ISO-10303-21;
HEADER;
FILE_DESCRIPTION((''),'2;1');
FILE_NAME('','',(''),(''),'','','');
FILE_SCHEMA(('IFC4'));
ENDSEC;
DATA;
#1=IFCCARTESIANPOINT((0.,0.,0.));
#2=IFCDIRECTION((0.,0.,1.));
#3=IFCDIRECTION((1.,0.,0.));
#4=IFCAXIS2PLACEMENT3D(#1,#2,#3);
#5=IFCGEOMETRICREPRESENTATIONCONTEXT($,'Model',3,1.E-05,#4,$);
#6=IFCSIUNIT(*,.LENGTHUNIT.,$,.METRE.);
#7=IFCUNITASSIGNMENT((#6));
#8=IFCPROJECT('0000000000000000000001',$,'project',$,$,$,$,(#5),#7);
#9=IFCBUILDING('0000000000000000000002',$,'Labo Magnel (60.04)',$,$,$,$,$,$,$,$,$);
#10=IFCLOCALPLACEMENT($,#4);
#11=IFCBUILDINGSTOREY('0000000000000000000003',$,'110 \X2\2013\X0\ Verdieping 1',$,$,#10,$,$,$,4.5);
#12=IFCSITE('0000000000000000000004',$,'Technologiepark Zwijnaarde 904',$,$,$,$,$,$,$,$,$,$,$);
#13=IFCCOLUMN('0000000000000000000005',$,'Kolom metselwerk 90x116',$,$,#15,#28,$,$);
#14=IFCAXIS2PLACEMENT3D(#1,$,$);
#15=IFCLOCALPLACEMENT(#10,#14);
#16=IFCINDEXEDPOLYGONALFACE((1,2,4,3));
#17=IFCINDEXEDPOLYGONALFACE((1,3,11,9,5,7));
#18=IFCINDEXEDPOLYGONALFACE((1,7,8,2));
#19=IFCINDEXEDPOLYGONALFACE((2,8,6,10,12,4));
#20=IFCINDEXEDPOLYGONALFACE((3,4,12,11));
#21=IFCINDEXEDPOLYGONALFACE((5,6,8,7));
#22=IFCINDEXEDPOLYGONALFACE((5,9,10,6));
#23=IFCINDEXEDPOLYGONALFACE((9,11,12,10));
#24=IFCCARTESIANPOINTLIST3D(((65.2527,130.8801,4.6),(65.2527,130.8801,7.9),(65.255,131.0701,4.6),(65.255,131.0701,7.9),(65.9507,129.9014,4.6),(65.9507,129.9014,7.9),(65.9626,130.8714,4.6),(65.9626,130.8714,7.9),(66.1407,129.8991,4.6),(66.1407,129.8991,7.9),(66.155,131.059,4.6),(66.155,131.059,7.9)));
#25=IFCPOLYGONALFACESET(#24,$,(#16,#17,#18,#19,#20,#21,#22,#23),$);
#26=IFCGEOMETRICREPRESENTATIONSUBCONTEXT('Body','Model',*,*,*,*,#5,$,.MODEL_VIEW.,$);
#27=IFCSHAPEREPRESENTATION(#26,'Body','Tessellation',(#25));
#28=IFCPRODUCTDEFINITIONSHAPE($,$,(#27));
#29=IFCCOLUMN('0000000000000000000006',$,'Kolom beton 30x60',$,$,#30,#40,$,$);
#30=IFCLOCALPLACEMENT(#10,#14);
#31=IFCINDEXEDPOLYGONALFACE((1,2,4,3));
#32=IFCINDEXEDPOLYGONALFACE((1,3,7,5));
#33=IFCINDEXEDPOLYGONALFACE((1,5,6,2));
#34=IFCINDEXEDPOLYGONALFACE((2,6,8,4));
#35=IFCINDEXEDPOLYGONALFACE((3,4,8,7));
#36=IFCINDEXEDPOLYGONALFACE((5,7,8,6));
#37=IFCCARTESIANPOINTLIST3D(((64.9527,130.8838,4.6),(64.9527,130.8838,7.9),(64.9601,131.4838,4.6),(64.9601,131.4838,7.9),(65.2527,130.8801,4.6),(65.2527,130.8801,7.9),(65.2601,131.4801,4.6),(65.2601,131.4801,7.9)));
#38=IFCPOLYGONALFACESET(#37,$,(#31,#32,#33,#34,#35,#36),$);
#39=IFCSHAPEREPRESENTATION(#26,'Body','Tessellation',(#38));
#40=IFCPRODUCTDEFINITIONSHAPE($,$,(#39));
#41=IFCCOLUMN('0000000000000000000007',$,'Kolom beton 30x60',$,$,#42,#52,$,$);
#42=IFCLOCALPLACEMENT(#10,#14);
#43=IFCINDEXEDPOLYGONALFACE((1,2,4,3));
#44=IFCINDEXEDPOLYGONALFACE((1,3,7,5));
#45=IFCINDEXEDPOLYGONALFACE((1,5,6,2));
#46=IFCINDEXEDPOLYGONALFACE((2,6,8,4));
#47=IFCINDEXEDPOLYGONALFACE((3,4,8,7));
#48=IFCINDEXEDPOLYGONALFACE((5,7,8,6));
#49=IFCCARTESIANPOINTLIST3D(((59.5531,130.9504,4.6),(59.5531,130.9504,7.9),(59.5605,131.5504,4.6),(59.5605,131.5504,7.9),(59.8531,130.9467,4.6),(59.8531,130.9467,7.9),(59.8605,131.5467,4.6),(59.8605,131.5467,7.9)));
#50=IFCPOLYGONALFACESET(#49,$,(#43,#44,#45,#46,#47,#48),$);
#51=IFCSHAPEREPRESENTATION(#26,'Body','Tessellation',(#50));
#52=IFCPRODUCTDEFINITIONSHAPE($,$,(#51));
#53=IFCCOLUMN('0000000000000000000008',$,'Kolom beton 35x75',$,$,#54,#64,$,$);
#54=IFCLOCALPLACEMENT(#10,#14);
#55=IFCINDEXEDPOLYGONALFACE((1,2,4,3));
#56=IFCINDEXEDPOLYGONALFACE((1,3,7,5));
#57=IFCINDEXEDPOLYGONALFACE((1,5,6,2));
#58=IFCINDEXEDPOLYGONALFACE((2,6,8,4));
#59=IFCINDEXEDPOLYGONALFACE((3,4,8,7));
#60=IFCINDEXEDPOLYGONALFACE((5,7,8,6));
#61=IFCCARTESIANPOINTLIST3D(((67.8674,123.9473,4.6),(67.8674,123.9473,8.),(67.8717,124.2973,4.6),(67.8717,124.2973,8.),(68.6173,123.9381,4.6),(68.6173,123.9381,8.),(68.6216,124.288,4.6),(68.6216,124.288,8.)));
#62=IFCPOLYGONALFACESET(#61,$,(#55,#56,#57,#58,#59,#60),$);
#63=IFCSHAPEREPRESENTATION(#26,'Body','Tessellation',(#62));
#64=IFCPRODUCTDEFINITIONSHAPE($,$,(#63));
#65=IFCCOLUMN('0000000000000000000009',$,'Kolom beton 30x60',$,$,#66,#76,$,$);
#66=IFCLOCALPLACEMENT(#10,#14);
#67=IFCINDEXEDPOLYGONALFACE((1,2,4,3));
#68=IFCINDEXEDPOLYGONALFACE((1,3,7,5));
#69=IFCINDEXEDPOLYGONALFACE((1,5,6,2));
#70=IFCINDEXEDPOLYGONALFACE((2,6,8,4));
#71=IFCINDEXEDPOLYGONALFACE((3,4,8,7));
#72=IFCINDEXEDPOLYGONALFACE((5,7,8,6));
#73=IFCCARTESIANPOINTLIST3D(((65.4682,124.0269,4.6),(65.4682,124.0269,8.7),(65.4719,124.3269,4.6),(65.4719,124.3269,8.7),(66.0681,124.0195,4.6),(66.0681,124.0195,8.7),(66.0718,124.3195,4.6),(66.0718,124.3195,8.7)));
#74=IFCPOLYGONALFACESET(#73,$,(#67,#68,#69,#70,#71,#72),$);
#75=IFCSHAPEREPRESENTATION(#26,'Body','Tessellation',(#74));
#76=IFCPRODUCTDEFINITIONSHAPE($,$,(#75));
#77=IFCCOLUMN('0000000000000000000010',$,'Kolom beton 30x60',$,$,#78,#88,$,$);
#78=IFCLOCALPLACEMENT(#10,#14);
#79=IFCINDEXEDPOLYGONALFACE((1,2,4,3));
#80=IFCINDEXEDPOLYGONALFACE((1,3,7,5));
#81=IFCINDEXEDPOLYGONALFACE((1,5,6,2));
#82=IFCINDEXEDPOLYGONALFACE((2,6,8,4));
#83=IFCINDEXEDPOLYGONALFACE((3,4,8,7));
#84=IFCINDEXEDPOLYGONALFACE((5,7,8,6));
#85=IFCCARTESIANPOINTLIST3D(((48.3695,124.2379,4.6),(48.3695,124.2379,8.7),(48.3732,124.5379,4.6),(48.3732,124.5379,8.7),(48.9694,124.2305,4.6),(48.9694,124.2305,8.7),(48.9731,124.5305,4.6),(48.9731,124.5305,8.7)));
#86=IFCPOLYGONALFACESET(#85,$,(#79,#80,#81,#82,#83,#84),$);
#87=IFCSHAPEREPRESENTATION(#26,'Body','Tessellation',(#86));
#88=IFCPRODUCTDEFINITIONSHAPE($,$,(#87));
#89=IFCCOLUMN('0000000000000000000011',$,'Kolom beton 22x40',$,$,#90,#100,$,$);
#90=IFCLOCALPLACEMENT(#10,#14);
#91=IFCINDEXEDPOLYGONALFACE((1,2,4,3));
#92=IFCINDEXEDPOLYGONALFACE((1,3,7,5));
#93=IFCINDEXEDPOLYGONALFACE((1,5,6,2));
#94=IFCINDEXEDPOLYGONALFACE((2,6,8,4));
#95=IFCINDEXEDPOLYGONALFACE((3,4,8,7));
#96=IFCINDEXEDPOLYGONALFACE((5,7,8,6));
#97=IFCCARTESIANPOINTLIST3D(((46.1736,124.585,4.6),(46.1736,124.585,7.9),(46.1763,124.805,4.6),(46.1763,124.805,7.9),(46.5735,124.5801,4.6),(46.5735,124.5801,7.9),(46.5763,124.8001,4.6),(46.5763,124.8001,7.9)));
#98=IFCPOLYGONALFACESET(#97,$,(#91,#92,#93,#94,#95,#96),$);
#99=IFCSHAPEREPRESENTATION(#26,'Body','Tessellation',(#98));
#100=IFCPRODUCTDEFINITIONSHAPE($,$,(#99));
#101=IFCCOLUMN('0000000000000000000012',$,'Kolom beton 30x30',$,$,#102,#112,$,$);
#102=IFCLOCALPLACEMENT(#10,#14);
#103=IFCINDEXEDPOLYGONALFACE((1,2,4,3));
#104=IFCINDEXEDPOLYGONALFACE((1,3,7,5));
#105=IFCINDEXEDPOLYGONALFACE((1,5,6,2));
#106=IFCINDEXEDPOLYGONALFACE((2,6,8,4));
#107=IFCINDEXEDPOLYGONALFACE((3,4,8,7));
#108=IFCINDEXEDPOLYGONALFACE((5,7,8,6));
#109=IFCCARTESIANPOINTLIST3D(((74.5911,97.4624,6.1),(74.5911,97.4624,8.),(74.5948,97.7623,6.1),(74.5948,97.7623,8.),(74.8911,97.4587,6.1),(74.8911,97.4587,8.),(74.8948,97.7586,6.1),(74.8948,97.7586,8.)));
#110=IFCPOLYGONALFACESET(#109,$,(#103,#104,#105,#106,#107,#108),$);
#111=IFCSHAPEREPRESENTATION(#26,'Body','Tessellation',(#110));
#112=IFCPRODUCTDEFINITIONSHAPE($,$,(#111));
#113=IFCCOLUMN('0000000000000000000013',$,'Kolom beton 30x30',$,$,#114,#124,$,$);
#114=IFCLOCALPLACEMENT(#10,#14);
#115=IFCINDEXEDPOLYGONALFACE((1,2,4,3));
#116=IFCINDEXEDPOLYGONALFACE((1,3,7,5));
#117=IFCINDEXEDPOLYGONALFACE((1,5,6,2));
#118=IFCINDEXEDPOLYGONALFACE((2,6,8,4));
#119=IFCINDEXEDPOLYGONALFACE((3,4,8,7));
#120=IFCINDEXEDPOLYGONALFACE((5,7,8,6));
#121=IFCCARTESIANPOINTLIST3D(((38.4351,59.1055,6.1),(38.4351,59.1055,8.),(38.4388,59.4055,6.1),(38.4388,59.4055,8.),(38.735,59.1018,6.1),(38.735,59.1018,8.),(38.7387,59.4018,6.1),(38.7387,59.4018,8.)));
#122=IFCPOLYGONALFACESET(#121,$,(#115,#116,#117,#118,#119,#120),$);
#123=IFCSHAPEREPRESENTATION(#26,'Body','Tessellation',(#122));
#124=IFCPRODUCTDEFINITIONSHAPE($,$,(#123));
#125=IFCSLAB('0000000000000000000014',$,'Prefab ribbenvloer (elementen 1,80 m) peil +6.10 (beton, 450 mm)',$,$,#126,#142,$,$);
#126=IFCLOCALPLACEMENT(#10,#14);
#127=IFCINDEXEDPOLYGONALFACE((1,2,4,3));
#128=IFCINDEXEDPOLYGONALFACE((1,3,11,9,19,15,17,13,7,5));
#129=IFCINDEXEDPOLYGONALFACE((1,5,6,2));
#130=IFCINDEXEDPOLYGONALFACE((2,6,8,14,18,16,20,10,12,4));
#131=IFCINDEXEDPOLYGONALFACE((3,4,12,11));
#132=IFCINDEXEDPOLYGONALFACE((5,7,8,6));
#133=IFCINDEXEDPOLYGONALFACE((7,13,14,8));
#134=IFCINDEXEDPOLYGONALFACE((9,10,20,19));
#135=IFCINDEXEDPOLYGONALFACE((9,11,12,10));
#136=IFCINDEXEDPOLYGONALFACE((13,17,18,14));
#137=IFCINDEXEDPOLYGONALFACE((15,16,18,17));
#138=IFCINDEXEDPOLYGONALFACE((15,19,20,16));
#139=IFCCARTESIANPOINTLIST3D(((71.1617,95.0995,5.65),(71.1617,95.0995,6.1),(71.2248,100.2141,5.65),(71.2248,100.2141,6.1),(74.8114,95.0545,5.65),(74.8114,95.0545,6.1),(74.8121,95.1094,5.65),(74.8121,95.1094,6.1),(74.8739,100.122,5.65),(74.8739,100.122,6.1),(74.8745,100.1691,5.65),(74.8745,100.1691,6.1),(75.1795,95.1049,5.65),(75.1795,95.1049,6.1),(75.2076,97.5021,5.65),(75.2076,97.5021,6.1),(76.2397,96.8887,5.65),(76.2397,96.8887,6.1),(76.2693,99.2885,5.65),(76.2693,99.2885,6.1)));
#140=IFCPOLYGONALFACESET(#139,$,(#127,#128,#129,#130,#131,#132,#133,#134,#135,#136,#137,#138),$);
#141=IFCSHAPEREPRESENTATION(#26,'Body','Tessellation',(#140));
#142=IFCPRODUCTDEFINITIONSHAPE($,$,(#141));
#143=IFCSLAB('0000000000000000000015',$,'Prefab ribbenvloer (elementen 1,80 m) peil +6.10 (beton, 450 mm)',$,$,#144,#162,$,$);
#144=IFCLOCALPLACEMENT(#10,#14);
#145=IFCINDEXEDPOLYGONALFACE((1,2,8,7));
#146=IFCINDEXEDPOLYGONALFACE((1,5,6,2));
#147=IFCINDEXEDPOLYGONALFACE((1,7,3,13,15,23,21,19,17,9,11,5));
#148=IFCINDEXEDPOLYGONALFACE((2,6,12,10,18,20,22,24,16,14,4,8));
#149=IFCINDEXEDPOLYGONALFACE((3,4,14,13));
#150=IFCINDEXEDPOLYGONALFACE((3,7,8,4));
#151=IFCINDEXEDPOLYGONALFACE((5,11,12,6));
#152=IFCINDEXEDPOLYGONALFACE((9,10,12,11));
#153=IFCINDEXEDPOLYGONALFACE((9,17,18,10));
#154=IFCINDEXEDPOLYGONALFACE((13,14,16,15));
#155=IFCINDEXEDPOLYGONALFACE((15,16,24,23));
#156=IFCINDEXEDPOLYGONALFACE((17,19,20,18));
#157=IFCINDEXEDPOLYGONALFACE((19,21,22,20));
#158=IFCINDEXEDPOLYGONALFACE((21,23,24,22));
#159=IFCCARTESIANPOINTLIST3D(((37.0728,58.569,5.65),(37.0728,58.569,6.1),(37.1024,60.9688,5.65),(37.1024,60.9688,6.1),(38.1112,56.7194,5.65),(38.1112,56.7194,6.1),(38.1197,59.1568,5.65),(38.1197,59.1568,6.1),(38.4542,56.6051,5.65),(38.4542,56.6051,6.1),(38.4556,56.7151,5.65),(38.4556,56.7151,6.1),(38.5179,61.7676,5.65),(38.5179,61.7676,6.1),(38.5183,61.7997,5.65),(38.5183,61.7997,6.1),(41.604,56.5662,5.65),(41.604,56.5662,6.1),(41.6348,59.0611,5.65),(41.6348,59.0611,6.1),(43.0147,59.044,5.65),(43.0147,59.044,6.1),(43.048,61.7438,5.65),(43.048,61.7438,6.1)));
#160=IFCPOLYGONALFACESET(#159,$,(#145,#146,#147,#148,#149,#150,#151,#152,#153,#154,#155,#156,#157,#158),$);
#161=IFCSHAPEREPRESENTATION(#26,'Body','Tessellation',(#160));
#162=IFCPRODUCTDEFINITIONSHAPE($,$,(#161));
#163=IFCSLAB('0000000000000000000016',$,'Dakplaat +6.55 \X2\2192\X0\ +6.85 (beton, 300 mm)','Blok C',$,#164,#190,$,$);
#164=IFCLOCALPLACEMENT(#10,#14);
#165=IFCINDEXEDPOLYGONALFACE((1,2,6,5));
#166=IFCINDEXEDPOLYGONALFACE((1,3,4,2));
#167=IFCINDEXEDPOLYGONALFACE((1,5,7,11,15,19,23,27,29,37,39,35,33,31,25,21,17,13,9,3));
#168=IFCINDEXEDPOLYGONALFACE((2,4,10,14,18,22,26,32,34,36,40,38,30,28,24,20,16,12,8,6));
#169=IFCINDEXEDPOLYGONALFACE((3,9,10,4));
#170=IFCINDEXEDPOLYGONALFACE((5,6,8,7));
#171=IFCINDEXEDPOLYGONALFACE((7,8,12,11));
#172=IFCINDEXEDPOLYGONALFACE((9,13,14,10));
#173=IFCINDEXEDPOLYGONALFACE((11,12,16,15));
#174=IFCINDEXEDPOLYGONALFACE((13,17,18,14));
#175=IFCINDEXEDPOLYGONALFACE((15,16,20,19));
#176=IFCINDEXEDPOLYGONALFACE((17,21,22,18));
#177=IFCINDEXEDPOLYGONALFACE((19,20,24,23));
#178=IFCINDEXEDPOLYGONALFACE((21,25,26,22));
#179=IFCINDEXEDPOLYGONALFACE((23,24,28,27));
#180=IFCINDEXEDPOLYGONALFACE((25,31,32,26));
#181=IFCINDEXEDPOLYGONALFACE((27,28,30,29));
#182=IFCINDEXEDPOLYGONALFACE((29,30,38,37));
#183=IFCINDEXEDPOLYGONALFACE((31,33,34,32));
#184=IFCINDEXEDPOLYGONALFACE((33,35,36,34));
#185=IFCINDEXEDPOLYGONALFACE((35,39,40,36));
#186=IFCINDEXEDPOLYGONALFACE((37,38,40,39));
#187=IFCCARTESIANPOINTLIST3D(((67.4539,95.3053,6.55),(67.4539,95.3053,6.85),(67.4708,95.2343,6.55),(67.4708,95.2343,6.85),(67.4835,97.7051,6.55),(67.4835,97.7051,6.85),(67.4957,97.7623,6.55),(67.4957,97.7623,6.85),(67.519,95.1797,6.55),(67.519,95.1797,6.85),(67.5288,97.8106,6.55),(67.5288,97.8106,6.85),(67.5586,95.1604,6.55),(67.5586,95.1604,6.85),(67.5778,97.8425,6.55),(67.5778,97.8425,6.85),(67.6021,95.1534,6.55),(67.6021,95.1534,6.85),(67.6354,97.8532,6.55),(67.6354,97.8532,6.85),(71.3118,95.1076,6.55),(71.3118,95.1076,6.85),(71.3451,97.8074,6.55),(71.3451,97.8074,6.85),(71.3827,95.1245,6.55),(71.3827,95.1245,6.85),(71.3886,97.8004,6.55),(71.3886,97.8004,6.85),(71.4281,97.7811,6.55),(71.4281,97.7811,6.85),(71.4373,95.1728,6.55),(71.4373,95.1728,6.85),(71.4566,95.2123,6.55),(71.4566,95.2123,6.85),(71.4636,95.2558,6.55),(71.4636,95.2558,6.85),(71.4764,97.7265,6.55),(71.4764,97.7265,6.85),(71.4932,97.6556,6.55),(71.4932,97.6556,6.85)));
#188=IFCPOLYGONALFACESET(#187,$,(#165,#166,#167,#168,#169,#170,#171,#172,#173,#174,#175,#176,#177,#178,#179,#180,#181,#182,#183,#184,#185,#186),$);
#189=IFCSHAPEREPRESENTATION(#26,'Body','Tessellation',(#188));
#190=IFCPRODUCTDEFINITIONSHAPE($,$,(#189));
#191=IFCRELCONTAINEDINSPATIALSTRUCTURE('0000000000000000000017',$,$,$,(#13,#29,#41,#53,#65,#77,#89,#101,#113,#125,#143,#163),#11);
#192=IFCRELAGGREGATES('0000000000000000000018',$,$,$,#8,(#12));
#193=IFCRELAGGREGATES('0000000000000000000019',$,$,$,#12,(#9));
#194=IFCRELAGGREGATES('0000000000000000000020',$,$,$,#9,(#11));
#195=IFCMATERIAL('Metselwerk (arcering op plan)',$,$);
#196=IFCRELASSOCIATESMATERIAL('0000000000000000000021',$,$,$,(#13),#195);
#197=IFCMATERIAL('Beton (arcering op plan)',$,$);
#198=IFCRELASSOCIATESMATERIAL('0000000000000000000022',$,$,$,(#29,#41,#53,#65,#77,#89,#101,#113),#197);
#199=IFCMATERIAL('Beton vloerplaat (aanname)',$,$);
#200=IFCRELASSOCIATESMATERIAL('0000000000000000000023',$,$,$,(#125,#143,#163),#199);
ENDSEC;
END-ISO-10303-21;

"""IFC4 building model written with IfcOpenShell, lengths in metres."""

from ifc_helpers import new_model, si_unit, frame, origin, origin_with_axes, place, context, subcontext, project, spatial, polyline, outline, extrude, material, element, save


model = new_model("IFC4")

# Units and contexts
model_context = context("Model", 3, precision=1e-05, world=origin_with_axes())
body_context = subcontext(model_context, "Body", "Model", "MODEL_VIEW")
ifc_project = project(units=[si_unit("LENGTHUNIT", "METRE")], contexts=[model_context])

# Site, building, storey
site = spatial("IfcSite", under=ifc_project, Name="Technologiepark Zwijnaarde 904")
building = spatial("IfcBuilding", under=site, Name="Labo Magnel (60.04)")
storey_placement = place(None, origin_with_axes())
storey = spatial("IfcBuildingStorey", under=building, at=storey_placement, Name="110 – Verdieping 1", Elevation=4.5)

# Columns
ifc_material_1 = material(Name="Metselwerk (arcering op plan)")
column_1_placement = place(storey_placement, frame((0.0, 0.0, 4.6), z_axis=(0.0, 0.0, 1.0), x_axis=(1.0, 0.0, 0.0)))
element("IfcColumn", 1, at=column_1_placement, inside=storey, material=ifc_material_1, Name="Kolom metselwerk 90x116", context=body_context, shape_type="SweptSolid", body=[
    extrude(outline(polyline([(66.155, 131.059), (65.255, 131.0701), (65.2527, 130.8801), (65.9626, 130.8714), (65.9507, 129.9014), (66.1407, 129.8991), (66.155, 131.059)])), origin(), (0.0, 0.0, 1.0), 3.3),
])
ifc_material_2 = material(Name="Beton (arcering op plan)")
column_2_placement = place(storey_placement, frame((0.0, 0.0, 4.6), z_axis=(0.0, 0.0, 1.0), x_axis=(1.0, 0.0, 0.0)))
element("IfcColumn", 2, at=column_2_placement, inside=storey, material=ifc_material_2, Name="Kolom beton 30x60", context=body_context, shape_type="SweptSolid", body=[
    extrude(outline(polyline([(65.2601, 131.4801), (64.9601, 131.4838), (64.9527, 130.8838), (65.2527, 130.8801), (65.2601, 131.4801)])), origin(), (0.0, 0.0, 1.0), 3.3),
])
column_3_placement = place(storey_placement, frame((0.0, 0.0, 4.6), z_axis=(0.0, 0.0, 1.0), x_axis=(1.0, 0.0, 0.0)))
element("IfcColumn", 3, at=column_3_placement, inside=storey, material=ifc_material_2, Name="Kolom beton 30x60", context=body_context, shape_type="SweptSolid", body=[
    extrude(outline(polyline([(59.8605, 131.5467), (59.5605, 131.5504), (59.5531, 130.9504), (59.8531, 130.9467), (59.8605, 131.5467)])), origin(), (0.0, 0.0, 1.0), 3.3),
])
column_4_placement = place(storey_placement, frame((0.0, 0.0, 4.6), z_axis=(0.0, 0.0, 1.0), x_axis=(1.0, 0.0, 0.0)))
element("IfcColumn", 4, at=column_4_placement, inside=storey, material=ifc_material_2, Name="Kolom beton 35x75", context=body_context, shape_type="SweptSolid", body=[
    extrude(outline(polyline([(68.6173, 123.9381), (68.6216, 124.288), (67.8717, 124.2973), (67.8674, 123.9473), (68.6173, 123.9381)])), origin(), (0.0, 0.0, 1.0), 3.4),
])
column_5_placement = place(storey_placement, frame((0.0, 0.0, 4.6), z_axis=(0.0, 0.0, 1.0), x_axis=(1.0, 0.0, 0.0)))
element("IfcColumn", 5, at=column_5_placement, inside=storey, material=ifc_material_2, Name="Kolom beton 30x60", context=body_context, shape_type="SweptSolid", body=[
    extrude(outline(polyline([(66.0718, 124.3195), (65.4719, 124.3269), (65.4682, 124.0269), (66.0681, 124.0195), (66.0718, 124.3195)])), origin(), (0.0, 0.0, 1.0), 4.1),
])
column_6_placement = place(storey_placement, frame((0.0, 0.0, 4.6), z_axis=(0.0, 0.0, 1.0), x_axis=(1.0, 0.0, 0.0)))
element("IfcColumn", 6, at=column_6_placement, inside=storey, material=ifc_material_2, Name="Kolom beton 30x60", context=body_context, shape_type="SweptSolid", body=[
    extrude(outline(polyline([(48.9731, 124.5305), (48.3732, 124.5379), (48.3695, 124.2379), (48.9694, 124.2305), (48.9731, 124.5305)])), origin(), (0.0, 0.0, 1.0), 4.1),
])
column_7_placement = place(storey_placement, frame((0.0, 0.0, 4.6), z_axis=(0.0, 0.0, 1.0), x_axis=(1.0, 0.0, 0.0)))
element("IfcColumn", 7, at=column_7_placement, inside=storey, material=ifc_material_2, Name="Kolom beton 22x40", context=body_context, shape_type="SweptSolid", body=[
    extrude(outline(polyline([(46.5763, 124.8001), (46.1763, 124.805), (46.1736, 124.585), (46.5735, 124.5801), (46.5763, 124.8001)])), origin(), (0.0, 0.0, 1.0), 3.3),
])
column_8_placement = place(storey_placement, frame((0.0, 0.0, 6.1), z_axis=(0.0, 0.0, 1.0), x_axis=(1.0, 0.0, 0.0)))
element("IfcColumn", 8, at=column_8_placement, inside=storey, material=ifc_material_2, Name="Kolom beton 30x30", context=body_context, shape_type="SweptSolid", body=[
    extrude(outline(polyline([(74.8948, 97.7586), (74.5948, 97.7623), (74.5911, 97.4624), (74.8911, 97.4587), (74.8948, 97.7586)])), origin(), (0.0, 0.0, 1.0), 1.9),
])
column_9_placement = place(storey_placement, frame((0.0, 0.0, 6.1), z_axis=(0.0, 0.0, 1.0), x_axis=(1.0, 0.0, 0.0)))
element("IfcColumn", 9, at=column_9_placement, inside=storey, material=ifc_material_2, Name="Kolom beton 30x30", context=body_context, shape_type="SweptSolid", body=[
    extrude(outline(polyline([(38.7387, 59.4018), (38.4388, 59.4055), (38.4351, 59.1055), (38.735, 59.1018), (38.7387, 59.4018)])), origin(), (0.0, 0.0, 1.0), 1.9),
])

# Slabs
ifc_material_3 = material(Name="Beton vloerplaat (aanname)")
slab_1_placement = place(storey_placement, frame((0.0, 0.0, 5.65), z_axis=(0.0, 0.0, 1.0), x_axis=(1.0, 0.0, 0.0)))
element("IfcSlab", 10, at=slab_1_placement, inside=storey, material=ifc_material_3, Name="Prefab ribbenvloer (elementen 1,80 m) peil +6.10 (beton, 450 mm)", context=body_context, shape_type="SweptSolid", body=[
    extrude(outline(polyline([(75.1795, 95.1049), (74.8121, 95.1094), (74.8114, 95.0545), (71.1617, 95.0995), (71.2248, 100.2141), (74.8745, 100.1691), (74.8739, 100.122), (76.2693, 99.2885), (75.2076, 97.5021), (76.2397, 96.8887), (75.1795, 95.1049)])), origin(), (0.0, 0.0, 1.0), 0.45),
])
slab_2_placement = place(storey_placement, frame((0.0, 0.0, 5.65), z_axis=(0.0, 0.0, 1.0), x_axis=(1.0, 0.0, 0.0)))
element("IfcSlab", 11, at=slab_2_placement, inside=storey, material=ifc_material_3, Name="Prefab ribbenvloer (elementen 1,80 m) peil +6.10 (beton, 450 mm)", context=body_context, shape_type="SweptSolid", body=[
    extrude(outline(polyline([(38.4542, 56.6051), (38.4556, 56.7151), (38.1112, 56.7194), (37.0728, 58.569), (38.1197, 59.1568), (37.1024, 60.9688), (38.5179, 61.7676), (38.5183, 61.7997), (43.048, 61.7438), (43.0147, 59.044), (41.6348, 59.0611), (41.604, 56.5662), (38.4542, 56.6051)])), origin(), (0.0, 0.0, 1.0), 0.45),
])
slab_3_placement = place(storey_placement, frame((0.0, 0.0, 6.55), z_axis=(0.0, 0.0, 1.0), x_axis=(1.0, 0.0, 0.0)))
element("IfcSlab", 12, at=slab_3_placement, inside=storey, material=ifc_material_3, Name="Dakplaat +6.55 → +6.85 (beton, 300 mm)", Description="Blok C", context=body_context, shape_type="SweptSolid", body=[
    extrude(outline(polyline([(67.4835, 97.7051), (67.4957, 97.7623), (67.5288, 97.8106), (67.5778, 97.8425), (67.6354, 97.8532), (71.3451, 97.8074), (71.3886, 97.8004), (71.4281, 97.7811), (71.4764, 97.7265), (71.4932, 97.6556), (71.4636, 95.2558), (71.4566, 95.2123), (71.4373, 95.1728), (71.3827, 95.1245), (71.3118, 95.1076), (67.6021, 95.1534), (67.5586, 95.1604), (67.519, 95.1797), (67.4708, 95.2343), (67.4539, 95.3053), (67.4835, 97.7051)])), origin(), (0.0, 0.0, 1.0), 0.3),
])

save(model, "model.ifc")
